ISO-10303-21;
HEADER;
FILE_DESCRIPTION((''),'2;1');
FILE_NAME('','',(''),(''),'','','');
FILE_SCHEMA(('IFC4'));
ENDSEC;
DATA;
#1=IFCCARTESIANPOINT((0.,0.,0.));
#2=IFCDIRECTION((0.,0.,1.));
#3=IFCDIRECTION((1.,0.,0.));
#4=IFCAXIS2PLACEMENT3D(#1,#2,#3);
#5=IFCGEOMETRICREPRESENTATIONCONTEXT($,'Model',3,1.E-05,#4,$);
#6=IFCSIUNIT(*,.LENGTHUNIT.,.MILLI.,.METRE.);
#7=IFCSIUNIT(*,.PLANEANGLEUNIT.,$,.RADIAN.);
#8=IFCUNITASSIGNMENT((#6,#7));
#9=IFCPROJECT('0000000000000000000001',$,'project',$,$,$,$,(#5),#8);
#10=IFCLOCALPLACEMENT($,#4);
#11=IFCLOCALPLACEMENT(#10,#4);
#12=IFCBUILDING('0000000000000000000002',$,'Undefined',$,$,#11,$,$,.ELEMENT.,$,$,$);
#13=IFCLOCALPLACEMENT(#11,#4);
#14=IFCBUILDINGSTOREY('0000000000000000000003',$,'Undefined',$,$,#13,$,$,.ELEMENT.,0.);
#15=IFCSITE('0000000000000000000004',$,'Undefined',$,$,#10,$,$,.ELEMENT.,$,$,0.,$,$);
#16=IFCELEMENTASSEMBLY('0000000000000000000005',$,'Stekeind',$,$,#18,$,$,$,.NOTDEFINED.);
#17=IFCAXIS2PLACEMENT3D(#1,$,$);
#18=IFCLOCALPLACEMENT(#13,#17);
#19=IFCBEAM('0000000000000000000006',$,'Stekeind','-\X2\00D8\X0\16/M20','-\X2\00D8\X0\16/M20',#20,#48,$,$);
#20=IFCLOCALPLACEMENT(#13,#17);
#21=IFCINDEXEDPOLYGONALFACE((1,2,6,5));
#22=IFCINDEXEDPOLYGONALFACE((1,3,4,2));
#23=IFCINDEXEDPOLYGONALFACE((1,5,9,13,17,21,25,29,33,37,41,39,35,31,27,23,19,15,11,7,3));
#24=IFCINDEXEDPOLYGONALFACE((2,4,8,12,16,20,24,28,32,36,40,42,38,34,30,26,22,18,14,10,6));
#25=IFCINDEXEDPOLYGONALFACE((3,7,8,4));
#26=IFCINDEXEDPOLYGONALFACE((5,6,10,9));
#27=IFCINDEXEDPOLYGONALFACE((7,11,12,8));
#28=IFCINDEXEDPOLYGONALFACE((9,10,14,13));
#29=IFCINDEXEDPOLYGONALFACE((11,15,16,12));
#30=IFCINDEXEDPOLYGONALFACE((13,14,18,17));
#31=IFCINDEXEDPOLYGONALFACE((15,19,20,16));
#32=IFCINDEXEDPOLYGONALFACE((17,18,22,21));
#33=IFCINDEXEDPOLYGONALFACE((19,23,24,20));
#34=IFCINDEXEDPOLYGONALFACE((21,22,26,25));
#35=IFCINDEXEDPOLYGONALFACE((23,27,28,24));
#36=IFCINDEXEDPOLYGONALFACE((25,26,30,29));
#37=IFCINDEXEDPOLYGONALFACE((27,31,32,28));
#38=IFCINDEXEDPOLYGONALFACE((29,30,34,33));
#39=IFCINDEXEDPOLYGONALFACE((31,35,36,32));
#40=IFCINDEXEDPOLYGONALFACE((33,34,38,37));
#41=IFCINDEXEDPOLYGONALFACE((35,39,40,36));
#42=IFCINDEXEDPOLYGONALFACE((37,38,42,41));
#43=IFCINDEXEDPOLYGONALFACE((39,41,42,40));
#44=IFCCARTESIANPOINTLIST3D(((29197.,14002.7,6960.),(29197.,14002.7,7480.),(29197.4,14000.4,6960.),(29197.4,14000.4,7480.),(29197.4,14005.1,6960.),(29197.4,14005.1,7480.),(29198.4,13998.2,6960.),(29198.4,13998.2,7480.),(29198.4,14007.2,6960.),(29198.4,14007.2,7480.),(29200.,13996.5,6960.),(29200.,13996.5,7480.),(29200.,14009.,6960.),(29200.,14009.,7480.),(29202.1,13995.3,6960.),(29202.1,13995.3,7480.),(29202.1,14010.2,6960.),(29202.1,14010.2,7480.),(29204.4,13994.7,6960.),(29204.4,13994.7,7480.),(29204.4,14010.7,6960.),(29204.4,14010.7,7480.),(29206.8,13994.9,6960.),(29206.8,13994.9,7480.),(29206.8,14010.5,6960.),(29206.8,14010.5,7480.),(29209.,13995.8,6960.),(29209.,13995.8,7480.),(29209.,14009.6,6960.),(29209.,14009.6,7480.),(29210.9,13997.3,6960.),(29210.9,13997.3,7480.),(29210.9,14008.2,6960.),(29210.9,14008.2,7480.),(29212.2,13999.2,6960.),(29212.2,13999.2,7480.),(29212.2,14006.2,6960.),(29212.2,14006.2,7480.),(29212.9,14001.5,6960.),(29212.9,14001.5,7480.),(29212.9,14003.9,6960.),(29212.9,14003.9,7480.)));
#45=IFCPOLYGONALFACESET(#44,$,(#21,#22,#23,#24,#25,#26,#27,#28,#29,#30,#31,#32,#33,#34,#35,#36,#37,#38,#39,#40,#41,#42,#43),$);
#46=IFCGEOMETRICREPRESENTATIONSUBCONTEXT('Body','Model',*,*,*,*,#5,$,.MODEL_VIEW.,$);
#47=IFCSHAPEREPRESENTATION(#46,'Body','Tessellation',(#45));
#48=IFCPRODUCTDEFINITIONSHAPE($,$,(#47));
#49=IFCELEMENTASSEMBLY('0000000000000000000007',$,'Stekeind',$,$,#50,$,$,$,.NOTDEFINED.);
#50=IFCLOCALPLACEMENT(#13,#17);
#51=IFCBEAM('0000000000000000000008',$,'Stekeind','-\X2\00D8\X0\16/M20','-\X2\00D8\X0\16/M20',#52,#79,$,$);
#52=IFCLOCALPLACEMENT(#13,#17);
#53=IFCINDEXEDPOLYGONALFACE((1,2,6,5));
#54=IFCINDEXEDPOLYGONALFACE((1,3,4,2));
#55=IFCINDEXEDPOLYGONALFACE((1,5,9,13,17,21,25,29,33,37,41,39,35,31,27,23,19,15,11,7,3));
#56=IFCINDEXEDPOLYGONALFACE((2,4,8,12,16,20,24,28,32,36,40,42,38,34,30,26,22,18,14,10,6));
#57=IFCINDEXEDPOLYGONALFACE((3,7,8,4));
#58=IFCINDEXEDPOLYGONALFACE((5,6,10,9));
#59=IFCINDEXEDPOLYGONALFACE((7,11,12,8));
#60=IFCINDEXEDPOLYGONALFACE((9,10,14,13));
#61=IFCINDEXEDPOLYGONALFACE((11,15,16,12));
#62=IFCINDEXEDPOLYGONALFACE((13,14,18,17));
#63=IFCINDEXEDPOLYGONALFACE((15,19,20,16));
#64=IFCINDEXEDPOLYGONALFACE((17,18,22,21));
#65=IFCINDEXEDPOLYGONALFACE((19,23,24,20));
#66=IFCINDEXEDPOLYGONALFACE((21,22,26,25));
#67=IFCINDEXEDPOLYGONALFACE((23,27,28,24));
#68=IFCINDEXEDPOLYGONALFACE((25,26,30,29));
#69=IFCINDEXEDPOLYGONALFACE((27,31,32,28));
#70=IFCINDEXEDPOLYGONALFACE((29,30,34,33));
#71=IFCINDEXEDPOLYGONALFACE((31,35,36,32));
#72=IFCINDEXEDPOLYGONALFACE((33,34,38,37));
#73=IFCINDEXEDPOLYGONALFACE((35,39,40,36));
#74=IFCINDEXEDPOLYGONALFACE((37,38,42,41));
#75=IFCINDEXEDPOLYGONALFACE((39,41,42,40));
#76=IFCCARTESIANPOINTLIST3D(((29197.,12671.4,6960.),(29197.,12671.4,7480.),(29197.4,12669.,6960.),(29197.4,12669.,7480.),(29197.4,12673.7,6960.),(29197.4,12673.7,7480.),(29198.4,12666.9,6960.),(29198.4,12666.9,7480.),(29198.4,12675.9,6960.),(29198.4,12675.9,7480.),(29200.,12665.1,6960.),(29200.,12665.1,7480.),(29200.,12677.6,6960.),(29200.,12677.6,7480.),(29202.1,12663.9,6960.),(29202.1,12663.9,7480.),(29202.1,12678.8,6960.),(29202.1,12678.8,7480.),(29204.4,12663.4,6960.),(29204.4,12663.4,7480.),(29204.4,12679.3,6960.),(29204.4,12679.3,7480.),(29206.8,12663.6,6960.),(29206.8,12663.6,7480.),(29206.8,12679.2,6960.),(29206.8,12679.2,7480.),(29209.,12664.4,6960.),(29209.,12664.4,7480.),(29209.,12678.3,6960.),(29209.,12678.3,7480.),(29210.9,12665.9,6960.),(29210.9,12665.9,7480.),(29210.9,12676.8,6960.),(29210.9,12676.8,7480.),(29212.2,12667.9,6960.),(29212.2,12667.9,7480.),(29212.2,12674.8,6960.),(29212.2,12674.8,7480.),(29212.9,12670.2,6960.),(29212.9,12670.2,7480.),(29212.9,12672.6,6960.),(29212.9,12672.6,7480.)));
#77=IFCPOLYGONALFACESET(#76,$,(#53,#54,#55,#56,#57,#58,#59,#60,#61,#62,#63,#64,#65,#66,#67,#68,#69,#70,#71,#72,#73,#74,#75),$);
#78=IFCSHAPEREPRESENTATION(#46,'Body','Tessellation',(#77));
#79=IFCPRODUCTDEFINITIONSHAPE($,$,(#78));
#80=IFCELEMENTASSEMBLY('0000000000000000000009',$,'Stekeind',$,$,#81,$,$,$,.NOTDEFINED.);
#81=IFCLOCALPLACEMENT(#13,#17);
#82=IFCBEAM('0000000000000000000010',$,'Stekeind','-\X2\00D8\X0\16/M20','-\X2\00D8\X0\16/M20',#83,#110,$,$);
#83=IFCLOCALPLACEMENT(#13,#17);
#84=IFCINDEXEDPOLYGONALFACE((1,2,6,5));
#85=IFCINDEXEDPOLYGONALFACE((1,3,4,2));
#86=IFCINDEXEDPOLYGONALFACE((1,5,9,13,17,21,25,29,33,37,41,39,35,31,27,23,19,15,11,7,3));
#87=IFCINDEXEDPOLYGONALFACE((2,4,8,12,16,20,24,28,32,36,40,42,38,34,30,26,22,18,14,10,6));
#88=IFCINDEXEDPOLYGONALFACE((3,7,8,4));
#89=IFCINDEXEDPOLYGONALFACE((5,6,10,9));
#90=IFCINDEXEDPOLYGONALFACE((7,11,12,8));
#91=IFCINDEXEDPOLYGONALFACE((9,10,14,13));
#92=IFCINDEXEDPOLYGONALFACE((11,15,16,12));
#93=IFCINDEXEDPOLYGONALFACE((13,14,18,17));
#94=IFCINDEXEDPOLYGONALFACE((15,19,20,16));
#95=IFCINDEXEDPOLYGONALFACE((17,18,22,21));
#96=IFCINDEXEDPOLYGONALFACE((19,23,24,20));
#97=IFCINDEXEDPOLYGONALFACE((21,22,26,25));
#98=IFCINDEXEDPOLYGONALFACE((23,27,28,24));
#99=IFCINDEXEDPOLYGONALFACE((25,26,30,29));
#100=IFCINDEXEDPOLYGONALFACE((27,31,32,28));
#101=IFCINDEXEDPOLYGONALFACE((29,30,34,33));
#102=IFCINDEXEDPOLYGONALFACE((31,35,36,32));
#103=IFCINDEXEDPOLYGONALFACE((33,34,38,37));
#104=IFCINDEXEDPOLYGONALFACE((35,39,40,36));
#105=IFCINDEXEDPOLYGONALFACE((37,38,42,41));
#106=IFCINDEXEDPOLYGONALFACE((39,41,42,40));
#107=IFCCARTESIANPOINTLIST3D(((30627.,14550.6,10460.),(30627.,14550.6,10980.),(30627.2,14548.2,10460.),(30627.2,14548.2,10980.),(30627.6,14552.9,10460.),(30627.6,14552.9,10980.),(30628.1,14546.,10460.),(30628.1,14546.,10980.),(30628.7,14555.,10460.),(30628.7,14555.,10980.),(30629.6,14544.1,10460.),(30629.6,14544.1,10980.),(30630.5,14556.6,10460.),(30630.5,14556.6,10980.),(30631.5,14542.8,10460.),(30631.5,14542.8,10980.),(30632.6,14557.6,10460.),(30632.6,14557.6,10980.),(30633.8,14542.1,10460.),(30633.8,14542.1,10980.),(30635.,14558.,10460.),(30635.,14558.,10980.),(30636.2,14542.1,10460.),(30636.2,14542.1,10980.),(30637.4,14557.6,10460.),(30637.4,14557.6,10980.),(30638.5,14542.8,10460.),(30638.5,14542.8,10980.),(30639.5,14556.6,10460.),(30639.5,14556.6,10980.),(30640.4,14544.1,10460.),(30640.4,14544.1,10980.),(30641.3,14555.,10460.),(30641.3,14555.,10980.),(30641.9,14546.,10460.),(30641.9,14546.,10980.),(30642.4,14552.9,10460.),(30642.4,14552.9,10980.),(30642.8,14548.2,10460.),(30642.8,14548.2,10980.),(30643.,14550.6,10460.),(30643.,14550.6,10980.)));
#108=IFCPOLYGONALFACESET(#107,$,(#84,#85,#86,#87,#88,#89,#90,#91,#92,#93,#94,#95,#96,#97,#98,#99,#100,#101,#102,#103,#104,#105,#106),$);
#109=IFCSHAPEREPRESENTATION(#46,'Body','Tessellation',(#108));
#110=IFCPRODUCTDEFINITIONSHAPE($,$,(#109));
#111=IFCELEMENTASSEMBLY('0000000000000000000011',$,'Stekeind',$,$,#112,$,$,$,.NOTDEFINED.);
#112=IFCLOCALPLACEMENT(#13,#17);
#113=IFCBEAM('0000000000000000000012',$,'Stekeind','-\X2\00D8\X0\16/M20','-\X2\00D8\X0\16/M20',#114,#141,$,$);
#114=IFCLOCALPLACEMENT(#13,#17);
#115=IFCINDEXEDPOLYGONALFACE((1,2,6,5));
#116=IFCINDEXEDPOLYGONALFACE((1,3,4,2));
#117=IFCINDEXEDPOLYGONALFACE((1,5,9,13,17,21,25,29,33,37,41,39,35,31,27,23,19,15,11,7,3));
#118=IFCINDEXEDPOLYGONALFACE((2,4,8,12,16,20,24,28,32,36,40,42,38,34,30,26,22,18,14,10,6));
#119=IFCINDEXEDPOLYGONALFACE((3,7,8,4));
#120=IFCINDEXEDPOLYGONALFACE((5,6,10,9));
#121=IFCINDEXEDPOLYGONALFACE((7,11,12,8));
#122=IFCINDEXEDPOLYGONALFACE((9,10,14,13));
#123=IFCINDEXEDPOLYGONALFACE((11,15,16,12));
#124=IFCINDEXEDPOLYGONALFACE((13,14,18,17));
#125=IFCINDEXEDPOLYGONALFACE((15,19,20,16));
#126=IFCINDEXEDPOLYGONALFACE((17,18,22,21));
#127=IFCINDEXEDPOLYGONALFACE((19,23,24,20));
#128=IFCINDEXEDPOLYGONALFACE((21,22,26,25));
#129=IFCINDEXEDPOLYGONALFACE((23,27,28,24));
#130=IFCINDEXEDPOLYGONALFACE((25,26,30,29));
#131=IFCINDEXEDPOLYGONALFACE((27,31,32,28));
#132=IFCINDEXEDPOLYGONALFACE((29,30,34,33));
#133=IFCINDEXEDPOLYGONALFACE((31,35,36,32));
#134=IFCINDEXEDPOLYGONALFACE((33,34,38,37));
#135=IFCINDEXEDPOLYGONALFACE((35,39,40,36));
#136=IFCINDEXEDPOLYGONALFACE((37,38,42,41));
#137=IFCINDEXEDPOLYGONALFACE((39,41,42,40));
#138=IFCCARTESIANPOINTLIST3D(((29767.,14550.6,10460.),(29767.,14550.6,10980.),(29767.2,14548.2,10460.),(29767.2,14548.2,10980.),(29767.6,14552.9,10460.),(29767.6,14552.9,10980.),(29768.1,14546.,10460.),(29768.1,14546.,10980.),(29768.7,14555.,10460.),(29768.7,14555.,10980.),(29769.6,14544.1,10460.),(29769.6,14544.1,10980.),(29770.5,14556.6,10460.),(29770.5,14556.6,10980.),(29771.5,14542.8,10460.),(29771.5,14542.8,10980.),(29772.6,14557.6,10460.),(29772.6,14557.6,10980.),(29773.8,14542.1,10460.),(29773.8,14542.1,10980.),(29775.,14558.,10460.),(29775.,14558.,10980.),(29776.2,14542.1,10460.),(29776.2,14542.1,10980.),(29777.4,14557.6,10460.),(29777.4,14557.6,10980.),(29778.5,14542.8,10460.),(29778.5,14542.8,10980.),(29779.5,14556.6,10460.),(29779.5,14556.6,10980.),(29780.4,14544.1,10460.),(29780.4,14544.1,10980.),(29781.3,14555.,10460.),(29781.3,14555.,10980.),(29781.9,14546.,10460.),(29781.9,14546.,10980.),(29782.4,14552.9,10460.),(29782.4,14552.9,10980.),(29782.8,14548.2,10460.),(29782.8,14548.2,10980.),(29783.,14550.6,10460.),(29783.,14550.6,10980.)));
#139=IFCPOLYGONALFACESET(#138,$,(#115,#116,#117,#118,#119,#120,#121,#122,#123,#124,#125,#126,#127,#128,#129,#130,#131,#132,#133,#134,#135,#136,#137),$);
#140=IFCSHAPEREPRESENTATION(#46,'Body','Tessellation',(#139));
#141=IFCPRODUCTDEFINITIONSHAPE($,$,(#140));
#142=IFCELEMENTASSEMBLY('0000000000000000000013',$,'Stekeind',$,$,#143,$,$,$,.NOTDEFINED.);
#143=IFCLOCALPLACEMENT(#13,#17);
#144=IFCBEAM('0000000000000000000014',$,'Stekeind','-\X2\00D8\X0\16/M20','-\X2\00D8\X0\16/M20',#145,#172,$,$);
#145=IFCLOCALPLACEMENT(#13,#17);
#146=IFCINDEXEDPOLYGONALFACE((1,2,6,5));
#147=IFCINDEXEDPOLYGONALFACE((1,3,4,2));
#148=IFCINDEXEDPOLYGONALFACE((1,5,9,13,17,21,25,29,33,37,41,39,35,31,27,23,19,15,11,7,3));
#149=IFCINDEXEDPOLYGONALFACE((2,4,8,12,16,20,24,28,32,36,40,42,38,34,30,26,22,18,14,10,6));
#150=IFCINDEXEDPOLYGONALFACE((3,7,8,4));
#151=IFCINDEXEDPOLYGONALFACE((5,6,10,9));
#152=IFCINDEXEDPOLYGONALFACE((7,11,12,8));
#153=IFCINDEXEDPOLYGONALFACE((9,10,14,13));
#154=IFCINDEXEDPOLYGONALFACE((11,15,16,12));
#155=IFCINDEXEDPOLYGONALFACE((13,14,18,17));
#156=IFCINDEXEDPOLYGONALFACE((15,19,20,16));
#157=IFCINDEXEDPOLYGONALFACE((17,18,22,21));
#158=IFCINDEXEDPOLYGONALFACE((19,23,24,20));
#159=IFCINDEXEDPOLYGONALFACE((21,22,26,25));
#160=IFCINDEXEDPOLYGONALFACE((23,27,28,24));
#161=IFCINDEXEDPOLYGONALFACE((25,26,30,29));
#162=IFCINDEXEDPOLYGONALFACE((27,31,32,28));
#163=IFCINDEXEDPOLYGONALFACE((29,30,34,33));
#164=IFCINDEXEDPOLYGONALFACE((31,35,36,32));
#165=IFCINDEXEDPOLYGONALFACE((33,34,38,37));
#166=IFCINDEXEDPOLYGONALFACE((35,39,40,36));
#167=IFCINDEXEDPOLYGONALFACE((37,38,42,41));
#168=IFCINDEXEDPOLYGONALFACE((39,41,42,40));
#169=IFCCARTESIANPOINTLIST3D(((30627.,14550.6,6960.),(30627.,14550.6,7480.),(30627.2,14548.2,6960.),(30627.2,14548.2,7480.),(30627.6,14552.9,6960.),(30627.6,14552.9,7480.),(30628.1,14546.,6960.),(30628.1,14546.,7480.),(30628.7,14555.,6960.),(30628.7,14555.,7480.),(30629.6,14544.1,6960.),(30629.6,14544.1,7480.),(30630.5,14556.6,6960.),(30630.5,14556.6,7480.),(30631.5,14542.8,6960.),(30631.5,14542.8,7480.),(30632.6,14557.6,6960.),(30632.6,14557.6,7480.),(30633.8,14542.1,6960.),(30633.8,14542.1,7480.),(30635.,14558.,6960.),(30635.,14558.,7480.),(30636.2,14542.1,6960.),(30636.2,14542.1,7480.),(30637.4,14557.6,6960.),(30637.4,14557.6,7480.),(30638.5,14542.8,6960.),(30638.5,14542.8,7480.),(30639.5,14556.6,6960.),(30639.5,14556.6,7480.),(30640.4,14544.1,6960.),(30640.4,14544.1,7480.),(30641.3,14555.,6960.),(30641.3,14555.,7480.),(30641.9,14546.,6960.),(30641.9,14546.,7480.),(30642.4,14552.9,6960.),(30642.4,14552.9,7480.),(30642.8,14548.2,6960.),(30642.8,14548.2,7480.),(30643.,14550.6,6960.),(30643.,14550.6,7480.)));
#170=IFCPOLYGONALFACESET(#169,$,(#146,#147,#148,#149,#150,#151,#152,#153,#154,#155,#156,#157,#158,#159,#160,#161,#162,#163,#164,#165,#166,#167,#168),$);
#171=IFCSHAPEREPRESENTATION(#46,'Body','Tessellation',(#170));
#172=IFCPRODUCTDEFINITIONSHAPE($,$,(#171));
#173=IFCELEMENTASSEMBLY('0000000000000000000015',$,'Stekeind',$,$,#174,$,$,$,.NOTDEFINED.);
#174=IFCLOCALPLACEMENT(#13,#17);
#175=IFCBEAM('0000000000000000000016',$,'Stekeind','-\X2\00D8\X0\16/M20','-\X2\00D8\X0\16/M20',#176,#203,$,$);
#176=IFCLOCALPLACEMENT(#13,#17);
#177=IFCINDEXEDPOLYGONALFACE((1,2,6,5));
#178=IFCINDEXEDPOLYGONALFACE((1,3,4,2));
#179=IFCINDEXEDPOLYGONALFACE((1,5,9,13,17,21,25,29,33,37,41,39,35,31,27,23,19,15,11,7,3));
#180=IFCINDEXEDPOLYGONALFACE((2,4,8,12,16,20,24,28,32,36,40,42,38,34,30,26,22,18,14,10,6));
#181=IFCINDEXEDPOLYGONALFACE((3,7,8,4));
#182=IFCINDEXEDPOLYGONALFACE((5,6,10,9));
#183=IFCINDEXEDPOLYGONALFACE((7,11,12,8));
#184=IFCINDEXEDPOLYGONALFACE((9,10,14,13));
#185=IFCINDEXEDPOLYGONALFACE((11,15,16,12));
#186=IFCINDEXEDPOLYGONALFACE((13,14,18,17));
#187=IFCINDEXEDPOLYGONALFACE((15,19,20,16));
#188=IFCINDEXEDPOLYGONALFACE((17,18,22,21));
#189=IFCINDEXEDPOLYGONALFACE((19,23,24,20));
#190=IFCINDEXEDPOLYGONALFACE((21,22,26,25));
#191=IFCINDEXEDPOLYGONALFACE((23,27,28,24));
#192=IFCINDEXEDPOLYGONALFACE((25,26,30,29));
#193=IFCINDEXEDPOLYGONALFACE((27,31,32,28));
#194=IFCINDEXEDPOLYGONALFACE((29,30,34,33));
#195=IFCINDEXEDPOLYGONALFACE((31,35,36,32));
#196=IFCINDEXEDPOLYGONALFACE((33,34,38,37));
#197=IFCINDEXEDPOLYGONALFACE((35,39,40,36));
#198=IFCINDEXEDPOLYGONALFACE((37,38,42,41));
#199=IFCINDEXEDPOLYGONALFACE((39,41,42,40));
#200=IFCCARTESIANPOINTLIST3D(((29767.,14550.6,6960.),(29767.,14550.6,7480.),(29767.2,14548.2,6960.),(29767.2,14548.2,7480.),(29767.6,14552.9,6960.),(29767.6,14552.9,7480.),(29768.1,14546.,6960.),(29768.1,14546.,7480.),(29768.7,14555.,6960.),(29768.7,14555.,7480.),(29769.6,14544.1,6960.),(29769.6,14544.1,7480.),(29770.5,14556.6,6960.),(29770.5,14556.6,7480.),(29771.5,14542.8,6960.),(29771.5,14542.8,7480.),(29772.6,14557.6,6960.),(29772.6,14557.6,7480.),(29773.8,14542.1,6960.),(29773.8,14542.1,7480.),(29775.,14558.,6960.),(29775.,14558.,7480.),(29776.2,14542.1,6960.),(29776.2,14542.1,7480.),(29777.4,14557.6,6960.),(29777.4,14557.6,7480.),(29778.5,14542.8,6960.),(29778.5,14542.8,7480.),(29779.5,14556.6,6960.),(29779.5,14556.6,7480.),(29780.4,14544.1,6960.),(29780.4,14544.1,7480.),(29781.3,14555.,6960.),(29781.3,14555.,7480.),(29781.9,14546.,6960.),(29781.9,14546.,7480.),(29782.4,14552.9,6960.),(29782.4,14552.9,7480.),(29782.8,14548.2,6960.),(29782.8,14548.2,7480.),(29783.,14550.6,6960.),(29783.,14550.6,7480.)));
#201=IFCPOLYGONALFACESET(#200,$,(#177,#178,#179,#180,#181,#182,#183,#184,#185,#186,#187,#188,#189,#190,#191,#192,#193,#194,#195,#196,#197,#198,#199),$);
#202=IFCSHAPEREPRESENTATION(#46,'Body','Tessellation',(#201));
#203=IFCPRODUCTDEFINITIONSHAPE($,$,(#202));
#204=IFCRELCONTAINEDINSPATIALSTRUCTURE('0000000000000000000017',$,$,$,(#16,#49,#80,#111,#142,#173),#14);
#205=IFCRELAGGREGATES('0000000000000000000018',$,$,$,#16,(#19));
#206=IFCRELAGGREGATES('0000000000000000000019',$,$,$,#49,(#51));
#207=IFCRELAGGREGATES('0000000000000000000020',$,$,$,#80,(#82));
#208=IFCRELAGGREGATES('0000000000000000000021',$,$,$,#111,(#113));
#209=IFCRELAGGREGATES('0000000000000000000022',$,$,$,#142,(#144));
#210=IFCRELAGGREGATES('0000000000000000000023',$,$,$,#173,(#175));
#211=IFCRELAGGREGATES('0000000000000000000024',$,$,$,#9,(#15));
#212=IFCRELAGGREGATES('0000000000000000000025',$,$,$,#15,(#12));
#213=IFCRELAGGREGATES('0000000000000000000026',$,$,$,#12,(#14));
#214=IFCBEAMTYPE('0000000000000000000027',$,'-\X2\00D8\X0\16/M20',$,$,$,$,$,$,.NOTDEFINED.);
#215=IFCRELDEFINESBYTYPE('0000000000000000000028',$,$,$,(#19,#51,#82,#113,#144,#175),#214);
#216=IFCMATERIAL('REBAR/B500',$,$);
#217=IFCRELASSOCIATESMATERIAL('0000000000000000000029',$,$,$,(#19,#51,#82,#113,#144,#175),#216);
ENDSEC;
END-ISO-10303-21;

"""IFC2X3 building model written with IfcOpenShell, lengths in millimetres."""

from ifc_helpers import new_model, si_unit, frame, origin_with_axes, origin_2d_with_axis, place, context, subcontext, project, spatial, circle, extrude, material, type_object, element, aggregate, save


model = new_model("IFC2X3")

# Units and contexts
model_context = context("Model", 3, precision=1e-05, world=origin_with_axes())
body_context = subcontext(model_context, "Body", "Model", "MODEL_VIEW")
ifc_project = project(units=[si_unit("LENGTHUNIT", "METRE", prefix="MILLI"), si_unit("PLANEANGLEUNIT", "RADIAN")], contexts=[model_context])

# Site, building, storey
site_placement = place(None, origin_with_axes())
site = spatial("IfcSite", under=ifc_project, at=site_placement, Name="Undefined", CompositionType="ELEMENT", RefElevation=0.0)
building_placement = place(site_placement, origin_with_axes())
building = spatial("IfcBuilding", under=site, at=building_placement, Name="Undefined", CompositionType="ELEMENT")
storey_placement = place(building_placement, origin_with_axes())
storey = spatial("IfcBuildingStorey", under=building, at=storey_placement, Name="Undefined", CompositionType="ELEMENT", Elevation=0.0)

# Element assemblies, beams
ifc_material_1 = material(Name="REBAR/B500")
beam_type_1 = type_object("IfcBeamType", Name="-Ø16/M20", PredefinedType="NOTDEFINED")
assembly_1_placement = place(storey_placement, origin_with_axes())
assembly_1 = element("IfcElementAssembly", 1, at=assembly_1_placement, inside=storey, Name="Stekeind", PredefinedType="NOTDEFINED")
beam_1_placement = place(assembly_1_placement, frame((29205.0, 14002.7, 7480.0), z_axis=(0.0, -1.0, 0.0), x_axis=(0.0, 0.0, -1.0)))
beam_1 = element("IfcBeam", 2, at=beam_1_placement, type_object=beam_type_1, material=ifc_material_1, Name="Stekeind", Description="-Ø16/M20", ObjectType="-Ø16/M20", context=body_context, shape_type="SweptSolid", body=[
    extrude(circle(Radius=8.0, at=origin_2d_with_axis()), frame((520.0, 0.0, 0.0), z_axis=(-1.0, 0.0, 0.0), x_axis=(0.0, -1.0, 0.0)), (0.0, 0.0, 1.0), 520.0),
])
aggregate(assembly_1, [beam_1])
assembly_2_placement = place(storey_placement, origin_with_axes())
assembly_2 = element("IfcElementAssembly", 3, at=assembly_2_placement, inside=storey, Name="Stekeind", PredefinedType="NOTDEFINED")
beam_2_placement = place(assembly_2_placement, frame((29205.0, 12671.4, 7480.0), z_axis=(0.0, -1.0, 0.0), x_axis=(0.0, 0.0, -1.0)))
beam_2 = element("IfcBeam", 4, at=beam_2_placement, type_object=beam_type_1, material=ifc_material_1, Name="Stekeind", Description="-Ø16/M20", ObjectType="-Ø16/M20", context=body_context, shape_type="SweptSolid", body=[
    extrude(circle(Radius=8.0, at=origin_2d_with_axis()), frame((520.0, 0.0, 0.0), z_axis=(-1.0, 0.0, 0.0), x_axis=(0.0, -1.0, 0.0)), (0.0, 0.0, 1.0), 520.0),
])
aggregate(assembly_2, [beam_2])
assembly_3_placement = place(storey_placement, origin_with_axes())
assembly_3 = element("IfcElementAssembly", 5, at=assembly_3_placement, inside=storey, Name="Stekeind", PredefinedType="NOTDEFINED")
beam_3_placement = place(assembly_3_placement, frame((30635.0, 14550.0, 10980.0), z_axis=(-1.0, 0.0, 0.0), x_axis=(0.0, 0.0, -1.0)))
beam_3 = element("IfcBeam", 6, at=beam_3_placement, type_object=beam_type_1, material=ifc_material_1, Name="Stekeind", Description="-Ø16/M20", ObjectType="-Ø16/M20", context=body_context, shape_type="SweptSolid", body=[
    extrude(circle(Radius=8.0, at=origin_2d_with_axis()), frame((520.0, 0.0, 0.0), z_axis=(-1.0, 0.0, 0.0), x_axis=(0.0, -1.0, 0.0)), (0.0, 0.0, 1.0), 520.0),
])
aggregate(assembly_3, [beam_3])
assembly_4_placement = place(storey_placement, origin_with_axes())
assembly_4 = element("IfcElementAssembly", 7, at=assembly_4_placement, inside=storey, Name="Stekeind", PredefinedType="NOTDEFINED")
beam_4_placement = place(assembly_4_placement, frame((29775.0, 14550.0, 10980.0), z_axis=(-1.0, 0.0, 0.0), x_axis=(0.0, 0.0, -1.0)))
beam_4 = element("IfcBeam", 8, at=beam_4_placement, type_object=beam_type_1, material=ifc_material_1, Name="Stekeind", Description="-Ø16/M20", ObjectType="-Ø16/M20", context=body_context, shape_type="SweptSolid", body=[
    extrude(circle(Radius=8.0, at=origin_2d_with_axis()), frame((520.0, 0.0, 0.0), z_axis=(-1.0, 0.0, 0.0), x_axis=(0.0, -1.0, 0.0)), (0.0, 0.0, 1.0), 520.0),
])
aggregate(assembly_4, [beam_4])
assembly_5_placement = place(storey_placement, origin_with_axes())
assembly_5 = element("IfcElementAssembly", 9, at=assembly_5_placement, inside=storey, Name="Stekeind", PredefinedType="NOTDEFINED")
beam_5_placement = place(assembly_5_placement, frame((30635.0, 14550.0, 7480.0), z_axis=(-1.0, 0.0, 0.0), x_axis=(0.0, 0.0, -1.0)))
beam_5 = element("IfcBeam", 10, at=beam_5_placement, type_object=beam_type_1, material=ifc_material_1, Name="Stekeind", Description="-Ø16/M20", ObjectType="-Ø16/M20", context=body_context, shape_type="SweptSolid", body=[
    extrude(circle(Radius=8.0, at=origin_2d_with_axis()), frame((520.0, 0.0, 0.0), z_axis=(-1.0, 0.0, 0.0), x_axis=(0.0, -1.0, 0.0)), (0.0, 0.0, 1.0), 520.0),
])
aggregate(assembly_5, [beam_5])
assembly_6_placement = place(storey_placement, origin_with_axes())
assembly_6 = element("IfcElementAssembly", 11, at=assembly_6_placement, inside=storey, Name="Stekeind", PredefinedType="NOTDEFINED")
beam_6_placement = place(assembly_6_placement, frame((29775.0, 14550.0, 7480.0), z_axis=(-1.0, 0.0, 0.0), x_axis=(0.0, 0.0, -1.0)))
beam_6 = element("IfcBeam", 12, at=beam_6_placement, type_object=beam_type_1, material=ifc_material_1, Name="Stekeind", Description="-Ø16/M20", ObjectType="-Ø16/M20", context=body_context, shape_type="SweptSolid", body=[
    extrude(circle(Radius=8.0, at=origin_2d_with_axis()), frame((520.0, 0.0, 0.0), z_axis=(-1.0, 0.0, 0.0), x_axis=(0.0, -1.0, 0.0)), (0.0, 0.0, 1.0), 520.0),
])
aggregate(assembly_6, [beam_6])

save(model, "model.ifc")
